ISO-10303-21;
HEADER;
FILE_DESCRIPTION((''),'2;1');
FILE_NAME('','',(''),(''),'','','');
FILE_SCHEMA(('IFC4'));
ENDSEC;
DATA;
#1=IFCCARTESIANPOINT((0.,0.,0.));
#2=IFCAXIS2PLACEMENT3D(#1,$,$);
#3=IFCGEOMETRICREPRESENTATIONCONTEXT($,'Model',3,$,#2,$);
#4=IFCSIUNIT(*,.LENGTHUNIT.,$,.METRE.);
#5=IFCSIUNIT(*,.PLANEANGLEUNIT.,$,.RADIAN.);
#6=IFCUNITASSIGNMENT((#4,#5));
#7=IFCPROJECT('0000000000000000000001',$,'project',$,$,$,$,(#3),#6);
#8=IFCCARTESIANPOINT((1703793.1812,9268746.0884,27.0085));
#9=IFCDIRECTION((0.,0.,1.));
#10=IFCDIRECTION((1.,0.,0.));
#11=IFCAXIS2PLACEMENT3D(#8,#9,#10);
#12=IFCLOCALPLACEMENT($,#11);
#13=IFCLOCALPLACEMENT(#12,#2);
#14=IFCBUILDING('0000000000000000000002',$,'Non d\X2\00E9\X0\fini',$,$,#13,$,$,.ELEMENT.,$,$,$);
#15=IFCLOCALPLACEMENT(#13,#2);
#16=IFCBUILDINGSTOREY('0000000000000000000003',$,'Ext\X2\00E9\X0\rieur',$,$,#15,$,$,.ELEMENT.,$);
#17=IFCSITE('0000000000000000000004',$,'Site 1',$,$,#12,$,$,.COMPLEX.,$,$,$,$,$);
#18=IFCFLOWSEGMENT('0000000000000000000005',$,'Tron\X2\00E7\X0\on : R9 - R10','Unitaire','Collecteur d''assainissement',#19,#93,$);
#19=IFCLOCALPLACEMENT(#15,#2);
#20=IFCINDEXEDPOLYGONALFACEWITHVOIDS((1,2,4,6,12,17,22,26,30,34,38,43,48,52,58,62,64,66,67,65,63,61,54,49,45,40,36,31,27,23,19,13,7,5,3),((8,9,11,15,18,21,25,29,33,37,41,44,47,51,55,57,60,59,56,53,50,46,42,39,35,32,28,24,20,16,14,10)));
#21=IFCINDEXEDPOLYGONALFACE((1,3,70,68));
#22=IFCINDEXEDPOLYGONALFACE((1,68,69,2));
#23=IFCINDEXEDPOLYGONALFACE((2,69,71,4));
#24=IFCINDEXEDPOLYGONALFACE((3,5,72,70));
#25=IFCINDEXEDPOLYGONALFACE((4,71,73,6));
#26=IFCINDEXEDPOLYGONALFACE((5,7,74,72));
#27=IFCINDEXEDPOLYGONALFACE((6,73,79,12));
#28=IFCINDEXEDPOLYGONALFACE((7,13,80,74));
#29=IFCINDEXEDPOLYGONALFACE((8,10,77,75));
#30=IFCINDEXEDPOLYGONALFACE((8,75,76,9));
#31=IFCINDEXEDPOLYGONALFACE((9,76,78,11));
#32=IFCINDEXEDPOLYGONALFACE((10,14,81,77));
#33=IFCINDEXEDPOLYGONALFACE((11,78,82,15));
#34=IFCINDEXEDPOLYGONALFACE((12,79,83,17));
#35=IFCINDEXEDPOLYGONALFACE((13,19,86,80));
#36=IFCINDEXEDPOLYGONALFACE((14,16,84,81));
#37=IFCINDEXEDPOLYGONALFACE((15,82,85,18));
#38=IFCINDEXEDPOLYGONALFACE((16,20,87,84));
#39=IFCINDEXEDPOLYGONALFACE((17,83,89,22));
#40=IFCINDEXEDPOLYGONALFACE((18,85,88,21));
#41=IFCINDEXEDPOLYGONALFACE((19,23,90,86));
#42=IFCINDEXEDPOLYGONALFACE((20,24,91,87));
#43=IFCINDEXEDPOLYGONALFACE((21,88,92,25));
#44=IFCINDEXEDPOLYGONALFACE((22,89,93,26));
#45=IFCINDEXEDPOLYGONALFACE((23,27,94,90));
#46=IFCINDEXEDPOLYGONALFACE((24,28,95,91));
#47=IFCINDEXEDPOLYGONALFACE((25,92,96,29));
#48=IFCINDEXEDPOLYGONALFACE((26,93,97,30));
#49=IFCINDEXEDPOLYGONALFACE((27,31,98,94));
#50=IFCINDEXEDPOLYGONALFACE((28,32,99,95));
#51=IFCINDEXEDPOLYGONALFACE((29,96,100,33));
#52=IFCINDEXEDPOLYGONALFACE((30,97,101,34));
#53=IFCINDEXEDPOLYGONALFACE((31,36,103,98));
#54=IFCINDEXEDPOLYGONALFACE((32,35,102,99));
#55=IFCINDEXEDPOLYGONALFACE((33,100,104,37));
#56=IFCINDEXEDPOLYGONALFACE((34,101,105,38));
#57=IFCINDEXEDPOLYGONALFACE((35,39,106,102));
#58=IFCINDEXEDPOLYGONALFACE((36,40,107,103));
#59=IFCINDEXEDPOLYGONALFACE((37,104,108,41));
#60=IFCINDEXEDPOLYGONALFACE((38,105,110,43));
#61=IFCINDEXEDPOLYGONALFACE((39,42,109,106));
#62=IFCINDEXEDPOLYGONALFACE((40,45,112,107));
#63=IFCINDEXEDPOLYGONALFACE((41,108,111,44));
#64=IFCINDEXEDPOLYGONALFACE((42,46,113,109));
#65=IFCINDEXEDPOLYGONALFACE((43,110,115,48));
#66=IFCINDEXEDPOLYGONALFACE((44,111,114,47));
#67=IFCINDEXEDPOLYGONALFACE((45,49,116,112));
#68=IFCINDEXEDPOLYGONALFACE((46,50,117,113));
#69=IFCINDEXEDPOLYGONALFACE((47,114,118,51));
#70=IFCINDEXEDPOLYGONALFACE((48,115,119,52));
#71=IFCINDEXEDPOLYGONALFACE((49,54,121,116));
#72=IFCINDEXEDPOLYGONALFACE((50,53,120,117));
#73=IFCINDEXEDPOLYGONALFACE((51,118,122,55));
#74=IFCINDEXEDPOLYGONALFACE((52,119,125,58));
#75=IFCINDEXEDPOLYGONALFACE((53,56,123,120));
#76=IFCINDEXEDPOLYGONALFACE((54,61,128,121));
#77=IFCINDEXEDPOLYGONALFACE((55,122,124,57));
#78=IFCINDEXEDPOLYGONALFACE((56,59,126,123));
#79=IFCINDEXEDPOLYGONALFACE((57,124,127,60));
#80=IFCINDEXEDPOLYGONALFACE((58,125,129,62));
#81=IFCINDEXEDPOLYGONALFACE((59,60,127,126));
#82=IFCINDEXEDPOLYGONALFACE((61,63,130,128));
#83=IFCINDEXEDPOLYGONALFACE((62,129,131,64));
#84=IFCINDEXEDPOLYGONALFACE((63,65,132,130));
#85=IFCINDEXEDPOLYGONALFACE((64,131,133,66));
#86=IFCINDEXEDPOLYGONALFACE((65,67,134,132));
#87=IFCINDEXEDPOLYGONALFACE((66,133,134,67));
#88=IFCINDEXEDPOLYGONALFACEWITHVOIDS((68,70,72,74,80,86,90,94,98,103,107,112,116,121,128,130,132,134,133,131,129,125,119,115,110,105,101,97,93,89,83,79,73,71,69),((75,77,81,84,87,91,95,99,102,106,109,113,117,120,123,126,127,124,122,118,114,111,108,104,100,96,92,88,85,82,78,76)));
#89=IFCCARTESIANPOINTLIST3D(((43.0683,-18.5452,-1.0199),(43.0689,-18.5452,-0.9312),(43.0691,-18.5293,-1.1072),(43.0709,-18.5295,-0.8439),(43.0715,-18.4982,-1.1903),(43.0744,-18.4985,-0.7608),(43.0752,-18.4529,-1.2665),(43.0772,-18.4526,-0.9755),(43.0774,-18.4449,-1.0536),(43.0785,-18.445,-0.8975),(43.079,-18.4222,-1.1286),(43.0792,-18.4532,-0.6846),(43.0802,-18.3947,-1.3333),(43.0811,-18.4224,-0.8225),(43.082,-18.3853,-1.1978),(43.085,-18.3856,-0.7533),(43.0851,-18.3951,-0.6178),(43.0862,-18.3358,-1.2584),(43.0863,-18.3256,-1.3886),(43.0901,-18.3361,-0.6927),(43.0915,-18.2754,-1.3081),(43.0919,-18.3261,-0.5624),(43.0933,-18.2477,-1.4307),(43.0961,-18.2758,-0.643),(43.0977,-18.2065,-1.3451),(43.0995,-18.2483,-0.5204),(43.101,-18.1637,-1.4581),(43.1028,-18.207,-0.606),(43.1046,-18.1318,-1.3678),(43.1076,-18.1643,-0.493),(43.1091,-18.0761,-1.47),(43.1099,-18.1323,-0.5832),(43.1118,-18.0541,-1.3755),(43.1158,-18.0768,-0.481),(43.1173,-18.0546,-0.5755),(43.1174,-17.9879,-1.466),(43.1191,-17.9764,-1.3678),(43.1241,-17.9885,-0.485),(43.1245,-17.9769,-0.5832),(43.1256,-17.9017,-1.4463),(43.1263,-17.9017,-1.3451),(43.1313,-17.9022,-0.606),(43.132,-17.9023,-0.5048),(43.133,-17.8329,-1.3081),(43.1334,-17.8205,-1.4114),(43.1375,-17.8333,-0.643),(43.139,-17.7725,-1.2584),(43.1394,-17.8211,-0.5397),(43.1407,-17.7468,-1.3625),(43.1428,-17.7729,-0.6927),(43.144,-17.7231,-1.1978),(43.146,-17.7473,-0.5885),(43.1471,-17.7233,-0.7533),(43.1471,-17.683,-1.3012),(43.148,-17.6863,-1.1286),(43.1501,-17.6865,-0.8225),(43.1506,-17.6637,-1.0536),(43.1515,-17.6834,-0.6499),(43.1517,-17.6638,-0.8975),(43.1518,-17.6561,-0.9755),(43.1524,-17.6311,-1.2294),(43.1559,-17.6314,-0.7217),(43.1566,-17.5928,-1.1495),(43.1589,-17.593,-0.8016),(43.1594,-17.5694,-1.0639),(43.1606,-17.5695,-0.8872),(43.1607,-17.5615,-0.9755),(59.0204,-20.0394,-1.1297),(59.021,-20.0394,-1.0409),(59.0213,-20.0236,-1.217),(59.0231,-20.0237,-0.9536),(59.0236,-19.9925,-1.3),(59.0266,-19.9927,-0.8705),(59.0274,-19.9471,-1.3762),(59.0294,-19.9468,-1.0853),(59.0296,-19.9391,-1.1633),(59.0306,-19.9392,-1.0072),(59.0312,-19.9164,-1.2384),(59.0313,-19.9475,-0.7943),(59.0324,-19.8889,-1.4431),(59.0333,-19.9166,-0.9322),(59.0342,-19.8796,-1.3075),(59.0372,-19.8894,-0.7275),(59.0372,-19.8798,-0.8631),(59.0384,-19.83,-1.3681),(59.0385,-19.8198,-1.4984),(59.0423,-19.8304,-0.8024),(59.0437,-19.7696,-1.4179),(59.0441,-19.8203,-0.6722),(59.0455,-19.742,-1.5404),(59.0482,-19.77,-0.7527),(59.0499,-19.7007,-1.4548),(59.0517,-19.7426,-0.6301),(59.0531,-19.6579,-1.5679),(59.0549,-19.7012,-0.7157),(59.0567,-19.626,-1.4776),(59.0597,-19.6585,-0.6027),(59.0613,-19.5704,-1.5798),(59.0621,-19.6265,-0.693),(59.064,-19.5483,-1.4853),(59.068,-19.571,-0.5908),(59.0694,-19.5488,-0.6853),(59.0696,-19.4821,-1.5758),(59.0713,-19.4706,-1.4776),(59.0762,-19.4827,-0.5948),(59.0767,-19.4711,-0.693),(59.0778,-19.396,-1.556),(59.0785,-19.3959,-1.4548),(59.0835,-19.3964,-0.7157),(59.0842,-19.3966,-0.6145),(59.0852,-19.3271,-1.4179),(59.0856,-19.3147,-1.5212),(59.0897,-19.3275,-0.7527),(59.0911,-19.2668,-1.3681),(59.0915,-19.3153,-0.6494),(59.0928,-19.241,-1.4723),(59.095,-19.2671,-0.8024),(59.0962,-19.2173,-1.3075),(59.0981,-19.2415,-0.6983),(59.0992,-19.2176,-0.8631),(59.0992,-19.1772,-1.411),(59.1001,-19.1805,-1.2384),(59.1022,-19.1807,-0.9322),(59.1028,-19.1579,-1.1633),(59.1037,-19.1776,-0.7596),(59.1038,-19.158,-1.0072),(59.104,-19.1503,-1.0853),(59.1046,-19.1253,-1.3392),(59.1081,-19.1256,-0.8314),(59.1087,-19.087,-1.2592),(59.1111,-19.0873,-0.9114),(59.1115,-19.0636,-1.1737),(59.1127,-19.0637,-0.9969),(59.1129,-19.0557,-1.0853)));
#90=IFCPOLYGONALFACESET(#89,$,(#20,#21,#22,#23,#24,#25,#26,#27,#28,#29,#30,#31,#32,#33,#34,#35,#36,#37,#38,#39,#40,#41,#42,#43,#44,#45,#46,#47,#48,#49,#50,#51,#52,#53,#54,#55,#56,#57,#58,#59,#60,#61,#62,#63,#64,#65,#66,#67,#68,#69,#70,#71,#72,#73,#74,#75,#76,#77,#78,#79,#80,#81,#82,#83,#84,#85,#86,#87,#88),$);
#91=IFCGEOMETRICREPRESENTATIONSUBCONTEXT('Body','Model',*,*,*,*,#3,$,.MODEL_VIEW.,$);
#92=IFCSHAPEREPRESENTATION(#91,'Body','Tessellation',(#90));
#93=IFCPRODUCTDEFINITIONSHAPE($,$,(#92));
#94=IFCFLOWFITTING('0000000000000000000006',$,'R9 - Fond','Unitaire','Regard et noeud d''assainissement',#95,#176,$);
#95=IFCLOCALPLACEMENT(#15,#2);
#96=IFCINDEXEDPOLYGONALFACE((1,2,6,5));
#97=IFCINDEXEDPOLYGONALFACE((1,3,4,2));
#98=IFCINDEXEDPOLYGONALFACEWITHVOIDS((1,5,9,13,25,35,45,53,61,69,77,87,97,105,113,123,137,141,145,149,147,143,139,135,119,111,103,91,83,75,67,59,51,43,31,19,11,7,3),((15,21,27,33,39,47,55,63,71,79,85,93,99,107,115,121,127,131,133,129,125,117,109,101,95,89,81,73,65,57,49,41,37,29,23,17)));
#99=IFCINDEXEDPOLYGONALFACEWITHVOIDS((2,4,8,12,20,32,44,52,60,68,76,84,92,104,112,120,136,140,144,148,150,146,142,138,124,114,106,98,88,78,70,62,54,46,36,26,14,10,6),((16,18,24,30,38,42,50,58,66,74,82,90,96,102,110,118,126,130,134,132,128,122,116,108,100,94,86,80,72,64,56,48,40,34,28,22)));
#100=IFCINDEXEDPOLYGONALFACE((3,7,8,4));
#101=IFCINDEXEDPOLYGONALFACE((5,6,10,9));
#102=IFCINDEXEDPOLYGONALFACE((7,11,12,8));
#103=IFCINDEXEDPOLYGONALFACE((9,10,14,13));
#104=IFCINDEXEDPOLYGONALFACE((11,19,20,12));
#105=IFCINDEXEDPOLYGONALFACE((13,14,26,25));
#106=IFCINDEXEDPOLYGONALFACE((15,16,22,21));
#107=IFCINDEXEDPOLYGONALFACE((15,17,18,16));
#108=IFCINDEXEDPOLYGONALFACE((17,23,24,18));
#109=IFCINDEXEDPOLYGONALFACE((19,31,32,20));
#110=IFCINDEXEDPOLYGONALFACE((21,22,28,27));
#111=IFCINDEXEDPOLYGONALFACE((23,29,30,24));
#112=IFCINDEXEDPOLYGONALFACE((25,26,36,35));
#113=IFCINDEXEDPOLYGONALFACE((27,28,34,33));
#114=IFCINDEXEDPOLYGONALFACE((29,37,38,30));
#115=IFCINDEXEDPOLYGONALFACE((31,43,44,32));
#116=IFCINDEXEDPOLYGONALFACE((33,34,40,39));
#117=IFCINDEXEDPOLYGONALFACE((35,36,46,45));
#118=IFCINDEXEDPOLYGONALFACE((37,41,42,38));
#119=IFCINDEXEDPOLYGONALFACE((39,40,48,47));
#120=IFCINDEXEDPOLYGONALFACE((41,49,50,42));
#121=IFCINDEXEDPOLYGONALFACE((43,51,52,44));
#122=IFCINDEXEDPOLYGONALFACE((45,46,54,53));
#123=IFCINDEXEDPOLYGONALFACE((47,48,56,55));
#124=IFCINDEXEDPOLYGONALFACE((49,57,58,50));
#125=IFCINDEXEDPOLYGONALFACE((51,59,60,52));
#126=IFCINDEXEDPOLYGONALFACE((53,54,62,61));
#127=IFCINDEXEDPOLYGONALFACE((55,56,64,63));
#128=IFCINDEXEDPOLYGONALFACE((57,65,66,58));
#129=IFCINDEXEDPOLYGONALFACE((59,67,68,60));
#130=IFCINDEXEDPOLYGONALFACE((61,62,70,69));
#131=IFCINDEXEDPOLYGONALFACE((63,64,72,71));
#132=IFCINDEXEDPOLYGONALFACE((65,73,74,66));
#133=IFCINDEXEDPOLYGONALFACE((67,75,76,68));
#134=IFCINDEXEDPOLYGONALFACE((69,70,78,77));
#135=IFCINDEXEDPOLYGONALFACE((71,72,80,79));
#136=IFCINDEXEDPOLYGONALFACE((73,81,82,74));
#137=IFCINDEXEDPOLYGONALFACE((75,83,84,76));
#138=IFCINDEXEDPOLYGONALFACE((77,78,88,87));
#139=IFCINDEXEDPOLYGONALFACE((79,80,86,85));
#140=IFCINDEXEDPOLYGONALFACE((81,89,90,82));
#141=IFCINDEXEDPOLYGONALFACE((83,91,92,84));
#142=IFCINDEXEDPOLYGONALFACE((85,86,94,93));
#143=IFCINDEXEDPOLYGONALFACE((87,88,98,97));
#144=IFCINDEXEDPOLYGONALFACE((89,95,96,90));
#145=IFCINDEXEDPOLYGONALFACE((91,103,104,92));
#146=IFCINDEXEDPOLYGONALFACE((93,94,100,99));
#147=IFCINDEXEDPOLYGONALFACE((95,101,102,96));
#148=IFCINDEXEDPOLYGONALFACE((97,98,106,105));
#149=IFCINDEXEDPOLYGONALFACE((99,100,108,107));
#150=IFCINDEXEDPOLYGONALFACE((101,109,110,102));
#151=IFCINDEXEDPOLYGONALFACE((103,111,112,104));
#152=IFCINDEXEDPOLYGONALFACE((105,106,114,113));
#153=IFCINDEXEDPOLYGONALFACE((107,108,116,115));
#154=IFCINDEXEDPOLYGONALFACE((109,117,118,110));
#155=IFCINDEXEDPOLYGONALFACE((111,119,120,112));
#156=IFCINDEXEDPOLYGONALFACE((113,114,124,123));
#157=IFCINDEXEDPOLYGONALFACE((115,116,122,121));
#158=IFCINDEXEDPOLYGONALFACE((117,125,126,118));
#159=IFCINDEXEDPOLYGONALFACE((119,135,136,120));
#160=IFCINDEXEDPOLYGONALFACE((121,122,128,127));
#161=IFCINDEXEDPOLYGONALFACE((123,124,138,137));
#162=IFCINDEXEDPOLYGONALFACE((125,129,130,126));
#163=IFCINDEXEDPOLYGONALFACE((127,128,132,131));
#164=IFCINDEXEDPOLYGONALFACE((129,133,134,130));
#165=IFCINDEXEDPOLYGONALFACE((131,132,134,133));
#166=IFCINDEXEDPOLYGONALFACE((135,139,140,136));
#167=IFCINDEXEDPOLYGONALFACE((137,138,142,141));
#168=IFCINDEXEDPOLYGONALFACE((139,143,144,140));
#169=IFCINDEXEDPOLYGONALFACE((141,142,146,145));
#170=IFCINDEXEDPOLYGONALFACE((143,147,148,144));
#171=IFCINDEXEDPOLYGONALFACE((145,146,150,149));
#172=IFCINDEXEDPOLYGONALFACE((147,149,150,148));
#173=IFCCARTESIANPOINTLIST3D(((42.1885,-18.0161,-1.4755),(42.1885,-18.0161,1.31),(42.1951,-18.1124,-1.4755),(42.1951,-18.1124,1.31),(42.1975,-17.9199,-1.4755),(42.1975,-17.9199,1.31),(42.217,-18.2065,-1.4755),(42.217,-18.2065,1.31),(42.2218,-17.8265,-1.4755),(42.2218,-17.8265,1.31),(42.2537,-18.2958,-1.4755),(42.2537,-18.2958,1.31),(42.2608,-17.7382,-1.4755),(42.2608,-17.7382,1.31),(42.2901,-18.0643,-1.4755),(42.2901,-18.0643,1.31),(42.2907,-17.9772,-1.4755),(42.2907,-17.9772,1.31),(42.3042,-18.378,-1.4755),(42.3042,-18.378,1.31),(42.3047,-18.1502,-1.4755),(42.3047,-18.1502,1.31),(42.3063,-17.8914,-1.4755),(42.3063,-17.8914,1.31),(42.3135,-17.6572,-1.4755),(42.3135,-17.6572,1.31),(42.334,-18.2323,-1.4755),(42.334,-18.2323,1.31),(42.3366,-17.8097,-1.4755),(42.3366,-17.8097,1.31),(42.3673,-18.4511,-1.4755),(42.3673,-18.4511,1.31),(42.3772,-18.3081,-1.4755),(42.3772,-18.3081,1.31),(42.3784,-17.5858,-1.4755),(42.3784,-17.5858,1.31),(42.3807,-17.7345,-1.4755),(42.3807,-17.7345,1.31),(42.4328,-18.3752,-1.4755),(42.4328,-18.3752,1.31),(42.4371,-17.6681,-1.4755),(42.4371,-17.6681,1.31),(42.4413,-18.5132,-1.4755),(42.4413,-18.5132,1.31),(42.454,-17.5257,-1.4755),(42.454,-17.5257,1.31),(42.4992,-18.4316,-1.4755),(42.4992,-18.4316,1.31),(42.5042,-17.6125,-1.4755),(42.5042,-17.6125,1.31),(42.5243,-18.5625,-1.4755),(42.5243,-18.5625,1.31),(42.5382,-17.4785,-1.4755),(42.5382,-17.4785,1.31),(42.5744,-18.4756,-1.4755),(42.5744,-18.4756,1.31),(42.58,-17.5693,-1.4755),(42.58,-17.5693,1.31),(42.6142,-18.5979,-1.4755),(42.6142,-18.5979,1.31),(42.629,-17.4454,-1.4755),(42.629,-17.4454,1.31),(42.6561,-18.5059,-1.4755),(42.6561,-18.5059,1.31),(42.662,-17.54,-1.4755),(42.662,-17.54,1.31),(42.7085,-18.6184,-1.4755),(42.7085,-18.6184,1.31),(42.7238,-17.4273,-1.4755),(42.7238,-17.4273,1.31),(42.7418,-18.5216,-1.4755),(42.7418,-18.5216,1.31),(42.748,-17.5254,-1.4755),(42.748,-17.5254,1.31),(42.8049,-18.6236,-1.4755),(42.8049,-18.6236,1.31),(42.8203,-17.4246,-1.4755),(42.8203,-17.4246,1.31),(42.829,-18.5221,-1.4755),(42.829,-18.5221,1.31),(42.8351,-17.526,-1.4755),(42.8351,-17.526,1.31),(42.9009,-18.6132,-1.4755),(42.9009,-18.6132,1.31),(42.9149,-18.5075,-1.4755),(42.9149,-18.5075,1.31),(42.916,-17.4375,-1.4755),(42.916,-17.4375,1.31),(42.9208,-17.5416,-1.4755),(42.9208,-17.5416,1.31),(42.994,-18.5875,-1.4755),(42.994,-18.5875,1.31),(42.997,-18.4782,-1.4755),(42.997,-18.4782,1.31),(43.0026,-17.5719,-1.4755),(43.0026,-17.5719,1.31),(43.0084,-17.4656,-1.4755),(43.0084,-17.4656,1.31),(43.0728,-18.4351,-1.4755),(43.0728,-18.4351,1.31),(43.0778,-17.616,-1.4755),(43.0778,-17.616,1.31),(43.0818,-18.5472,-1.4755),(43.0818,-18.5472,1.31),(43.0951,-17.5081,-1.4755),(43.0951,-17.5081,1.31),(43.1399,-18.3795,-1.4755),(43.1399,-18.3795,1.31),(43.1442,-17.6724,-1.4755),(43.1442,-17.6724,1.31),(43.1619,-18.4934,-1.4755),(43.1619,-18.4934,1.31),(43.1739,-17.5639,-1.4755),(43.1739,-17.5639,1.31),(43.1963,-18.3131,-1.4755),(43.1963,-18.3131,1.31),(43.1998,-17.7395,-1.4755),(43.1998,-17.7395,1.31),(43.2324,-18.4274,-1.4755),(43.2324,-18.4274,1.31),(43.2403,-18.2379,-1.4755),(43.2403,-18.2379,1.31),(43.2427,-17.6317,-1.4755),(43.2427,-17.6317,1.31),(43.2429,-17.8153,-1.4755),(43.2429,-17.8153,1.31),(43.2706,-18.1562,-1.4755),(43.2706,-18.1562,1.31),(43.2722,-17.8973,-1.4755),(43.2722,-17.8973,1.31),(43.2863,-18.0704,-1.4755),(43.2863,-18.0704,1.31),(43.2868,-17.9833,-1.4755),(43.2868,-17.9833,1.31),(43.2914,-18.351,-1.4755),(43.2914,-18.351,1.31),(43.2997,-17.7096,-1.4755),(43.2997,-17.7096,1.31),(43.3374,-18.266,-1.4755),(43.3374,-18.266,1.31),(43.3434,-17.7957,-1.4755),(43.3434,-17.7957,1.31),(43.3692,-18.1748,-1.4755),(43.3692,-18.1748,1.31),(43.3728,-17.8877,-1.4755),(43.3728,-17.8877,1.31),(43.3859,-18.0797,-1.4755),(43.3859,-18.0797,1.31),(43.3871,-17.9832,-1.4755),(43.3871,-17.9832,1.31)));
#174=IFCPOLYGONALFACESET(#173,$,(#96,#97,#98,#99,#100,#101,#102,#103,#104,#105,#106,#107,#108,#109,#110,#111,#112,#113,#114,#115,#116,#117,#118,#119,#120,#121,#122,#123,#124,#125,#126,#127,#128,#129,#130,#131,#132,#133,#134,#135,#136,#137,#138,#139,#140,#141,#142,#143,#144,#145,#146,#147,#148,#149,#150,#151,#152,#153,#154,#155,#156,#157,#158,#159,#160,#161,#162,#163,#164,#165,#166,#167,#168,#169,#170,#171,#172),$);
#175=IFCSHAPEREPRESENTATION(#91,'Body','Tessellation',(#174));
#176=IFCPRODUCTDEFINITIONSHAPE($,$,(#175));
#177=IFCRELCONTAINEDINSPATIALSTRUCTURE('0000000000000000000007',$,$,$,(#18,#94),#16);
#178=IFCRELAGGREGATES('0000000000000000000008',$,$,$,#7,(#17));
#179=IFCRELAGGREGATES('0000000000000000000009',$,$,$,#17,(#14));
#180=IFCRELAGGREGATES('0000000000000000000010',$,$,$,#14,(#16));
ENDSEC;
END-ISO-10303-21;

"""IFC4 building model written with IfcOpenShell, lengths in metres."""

from ifc_helpers import new_model, si_unit, frame, origin, origin_2d, place, context, subcontext, project, spatial, hollow_circle, extrude, element, save


model = new_model("IFC4")

# Units and contexts
model_context = context("Model", 3, world=origin())
body_context = subcontext(model_context, "Body", "Model", "MODEL_VIEW")
ifc_project = project(units=[si_unit("LENGTHUNIT", "METRE"), si_unit("PLANEANGLEUNIT", "RADIAN")], contexts=[model_context])

# Site, building, storey
site_placement = place(None, frame((1703793.1812, 9268746.0884, 27.0085), z_axis=(0.0, 0.0, 1.0), x_axis=(1.0, 0.0, 0.0)))
site = spatial("IfcSite", under=ifc_project, at=site_placement, Name="Site 1", CompositionType="COMPLEX")
building_placement = place(site_placement, origin())
building = spatial("IfcBuilding", under=site, at=building_placement, Name="Non défini", CompositionType="ELEMENT")
storey_placement = place(building_placement, origin())
storey = spatial("IfcBuildingStorey", under=building, at=storey_placement, Name="Extérieur", CompositionType="ELEMENT")

# Flow segment
flow_segment_1_placement = place(storey_placement, origin())
element("IfcFlowSegment", 1, at=flow_segment_1_placement, inside=storey, Name="Tronçon : R9 - R10", Description="Unitaire", ObjectType="Collecteur d'assainissement", context=body_context, shape_type="SweptSolid", body=[
    extrude(hollow_circle(Radius=0.495, WallThickness=0.095, at=origin_2d()), frame((43.1145, -18.0543, -0.9755), z_axis=(0.995618, -0.093259, -0.006849), x_axis=(0.093261, 0.995642, 0.0)), (0.0, 0.0, 1.0), 16.0224),
])

# Flow fitting
flow_fitting_1_placement = place(storey_placement, origin())
element("IfcFlowFitting", 2, at=flow_fitting_1_placement, inside=storey, Name="R9 - Fond", Description="Unitaire", ObjectType="Regard et noeud d'assainissement", context=body_context, shape_type="SweptSolid", body=[
    extrude(hollow_circle(Radius=0.6, WallThickness=0.1, at=origin_2d()), frame((42.7885, -18.0238, -1.4755), z_axis=(0.0, 0.0, 1.0), x_axis=(0.995642, -0.093261, 0.0)), (0.0, 0.0, 1.0), 2.7855),
])

save(model, "model.ifc")
